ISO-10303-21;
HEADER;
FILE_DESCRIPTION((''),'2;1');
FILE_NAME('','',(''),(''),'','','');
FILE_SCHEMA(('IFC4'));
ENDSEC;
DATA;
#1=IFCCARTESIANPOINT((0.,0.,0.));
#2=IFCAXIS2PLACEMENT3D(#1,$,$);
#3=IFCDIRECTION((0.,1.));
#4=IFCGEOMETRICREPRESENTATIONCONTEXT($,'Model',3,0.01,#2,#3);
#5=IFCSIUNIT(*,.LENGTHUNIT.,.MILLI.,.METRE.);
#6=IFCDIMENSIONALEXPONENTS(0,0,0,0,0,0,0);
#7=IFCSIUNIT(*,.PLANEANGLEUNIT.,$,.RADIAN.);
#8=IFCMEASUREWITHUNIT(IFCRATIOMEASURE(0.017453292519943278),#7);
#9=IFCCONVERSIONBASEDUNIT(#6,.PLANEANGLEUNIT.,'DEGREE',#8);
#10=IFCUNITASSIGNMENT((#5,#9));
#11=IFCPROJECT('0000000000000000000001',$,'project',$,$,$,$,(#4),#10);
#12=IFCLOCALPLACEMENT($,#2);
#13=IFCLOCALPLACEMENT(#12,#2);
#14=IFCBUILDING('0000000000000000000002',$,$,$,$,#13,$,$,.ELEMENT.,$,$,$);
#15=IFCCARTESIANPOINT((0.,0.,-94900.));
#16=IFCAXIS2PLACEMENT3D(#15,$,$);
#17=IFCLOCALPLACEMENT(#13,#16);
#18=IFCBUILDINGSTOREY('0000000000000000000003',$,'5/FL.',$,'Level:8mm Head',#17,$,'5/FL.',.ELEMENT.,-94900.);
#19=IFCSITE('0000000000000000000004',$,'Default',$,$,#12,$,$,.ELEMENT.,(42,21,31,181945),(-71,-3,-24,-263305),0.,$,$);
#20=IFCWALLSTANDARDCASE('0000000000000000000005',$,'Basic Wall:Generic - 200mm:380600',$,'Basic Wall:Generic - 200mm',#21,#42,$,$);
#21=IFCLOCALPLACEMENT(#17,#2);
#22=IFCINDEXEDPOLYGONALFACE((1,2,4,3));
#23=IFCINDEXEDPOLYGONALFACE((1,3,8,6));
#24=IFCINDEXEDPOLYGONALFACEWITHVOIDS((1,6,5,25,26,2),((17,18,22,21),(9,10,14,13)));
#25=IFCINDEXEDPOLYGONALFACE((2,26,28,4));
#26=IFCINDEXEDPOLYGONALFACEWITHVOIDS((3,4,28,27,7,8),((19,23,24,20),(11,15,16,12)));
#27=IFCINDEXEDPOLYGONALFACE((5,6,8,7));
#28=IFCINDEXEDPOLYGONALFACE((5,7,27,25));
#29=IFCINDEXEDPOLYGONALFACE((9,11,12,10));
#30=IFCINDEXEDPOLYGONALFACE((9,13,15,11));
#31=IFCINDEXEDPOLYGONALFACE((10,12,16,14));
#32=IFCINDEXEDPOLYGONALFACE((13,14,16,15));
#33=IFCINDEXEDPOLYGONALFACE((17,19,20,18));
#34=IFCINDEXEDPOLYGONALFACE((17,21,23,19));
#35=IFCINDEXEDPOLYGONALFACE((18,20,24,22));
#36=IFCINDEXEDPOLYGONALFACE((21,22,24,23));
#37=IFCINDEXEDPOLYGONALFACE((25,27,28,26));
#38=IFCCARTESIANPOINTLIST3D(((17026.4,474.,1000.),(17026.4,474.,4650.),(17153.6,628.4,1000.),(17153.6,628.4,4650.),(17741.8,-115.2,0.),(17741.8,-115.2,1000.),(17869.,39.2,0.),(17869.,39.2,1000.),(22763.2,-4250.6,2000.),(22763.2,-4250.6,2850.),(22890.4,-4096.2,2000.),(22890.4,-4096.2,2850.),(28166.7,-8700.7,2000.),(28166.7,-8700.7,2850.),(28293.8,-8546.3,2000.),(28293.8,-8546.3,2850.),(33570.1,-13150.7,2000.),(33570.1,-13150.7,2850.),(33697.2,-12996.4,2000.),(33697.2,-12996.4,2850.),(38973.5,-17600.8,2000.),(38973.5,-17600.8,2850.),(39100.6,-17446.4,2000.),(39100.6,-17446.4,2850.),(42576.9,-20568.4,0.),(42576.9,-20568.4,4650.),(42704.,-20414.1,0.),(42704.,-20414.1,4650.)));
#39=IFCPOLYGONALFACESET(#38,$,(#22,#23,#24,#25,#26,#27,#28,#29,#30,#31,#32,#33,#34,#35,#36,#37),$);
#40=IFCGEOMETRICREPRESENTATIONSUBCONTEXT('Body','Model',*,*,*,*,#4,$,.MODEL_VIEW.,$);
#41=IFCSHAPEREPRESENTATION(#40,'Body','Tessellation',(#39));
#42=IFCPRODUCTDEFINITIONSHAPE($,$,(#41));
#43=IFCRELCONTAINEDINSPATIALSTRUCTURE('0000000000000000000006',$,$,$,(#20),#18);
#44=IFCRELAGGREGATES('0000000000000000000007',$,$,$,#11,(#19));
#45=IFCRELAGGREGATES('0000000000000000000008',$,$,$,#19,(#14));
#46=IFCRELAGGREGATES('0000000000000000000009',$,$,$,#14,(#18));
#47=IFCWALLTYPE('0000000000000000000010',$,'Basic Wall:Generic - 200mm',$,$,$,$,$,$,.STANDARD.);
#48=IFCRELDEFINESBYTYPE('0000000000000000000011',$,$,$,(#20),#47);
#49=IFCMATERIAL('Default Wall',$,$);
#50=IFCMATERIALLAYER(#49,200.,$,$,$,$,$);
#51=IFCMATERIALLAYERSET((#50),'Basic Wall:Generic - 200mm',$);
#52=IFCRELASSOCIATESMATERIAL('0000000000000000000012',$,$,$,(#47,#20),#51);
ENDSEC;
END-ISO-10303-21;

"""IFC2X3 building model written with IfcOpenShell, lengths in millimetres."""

from ifc_helpers import new_model, entity, si_unit, converted_unit, direction, frame, frame_2d, origin, place, context, subcontext, project, spatial, rectangle, extrude, material, layer, layer_set, layer_usage, type_object, element, save


model = new_model("IFC2X3")

# Units and contexts
model_context = context("Model", 3, precision=0.01, world=origin(), true_north=direction((0.0, 1.0)))
body_context = subcontext(model_context, "Body", "Model", "MODEL_VIEW")
ifc_project = project(units=[si_unit("LENGTHUNIT", "METRE", prefix="MILLI"), converted_unit("PLANEANGLEUNIT", "DEGREE", entity("IfcRatioMeasure", 0.017453292519943278), si_unit("PLANEANGLEUNIT", "RADIAN"), dimensions=[0, 0, 0, 0, 0, 0, 0])], contexts=[model_context])

# Site, building, storey
site_placement = place(None, origin())
site = spatial("IfcSite", under=ifc_project, at=site_placement, Name="Default", CompositionType="ELEMENT", RefLatitude=(42, 21, 31, 181945), RefLongitude=(-71, -3, -24, -263305), RefElevation=0.0)
building_placement = place(site_placement, origin())
building = spatial("IfcBuilding", under=site, at=building_placement, CompositionType="ELEMENT")
storey_placement = place(building_placement, frame((0.0, 0.0, -94900.0)))
storey = spatial("IfcBuildingStorey", under=building, at=storey_placement, Name="5/FL.", ObjectType="Level:8mm Head", LongName="5/FL.", CompositionType="ELEMENT", Elevation=-94900.0)

# Wall, openings
ifc_material_1 = material(Name="Default Wall")
ifc_layer = layer(ifc_material_1, 200.0)
ifc_layer_set = layer_set([ifc_layer], Name="Basic Wall:Generic - 200mm")
ifc_layer_usage = layer_usage(ifc_layer_set, "AXIS2", "NEGATIVE", 100.0)
wall_type = type_object("IfcWallType", Name="Basic Wall:Generic - 200mm", PredefinedType="STANDARD", material=ifc_layer_set)
wall_1_placement = place(storey_placement, frame((42640.5, -20491.3, 0.0), z_axis=(0.0, 0.0, 1.0), x_axis=(-0.771917, 0.635723, 0.0)))
wall_1 = element("IfcWallStandardCase", 1, at=wall_1_placement, inside=storey, type_object=wall_type, material=ifc_layer_usage, Name="Basic Wall:Generic - 200mm:380600", ObjectType="Basic Wall:Generic - 200mm", context=body_context, shape_type="SweptSolid", body=[
    extrude(rectangle(XDim=33100.0, YDim=200.0, at=frame_2d((16550.0, 0.0), x_axis=(-1.0, 0.0))), origin(), (0.0, 0.0, 1.0), 4650.0),
])
opening_1_placement = place(wall_1_placement, origin())
element("IfcOpeningElement", 2, at=opening_1_placement, cuts=wall_1, ObjectType="Opening", context=body_context, shape_type="SweptSolid", body=[
    extrude(rectangle(XDim=850.0, YDim=7000.0, at=frame_2d((0.0, 0.0), x_axis=(1.0, 0.0))), frame((8168.1, -100.0, 2425.0), z_axis=(0.0, 1.0, 0.0), x_axis=(0.0, 0.0, -1.0)), (0.0, 0.0, 1.0), 200.0),
])
opening_2_placement = place(wall_1_placement, origin())
element("IfcOpeningElement", 3, at=opening_2_placement, cuts=wall_1, ObjectType="Opening", context=body_context, shape_type="SweptSolid", body=[
    extrude(rectangle(XDim=850.0, YDim=7000.0, at=frame_2d((0.0, 0.0), x_axis=(1.0, 0.0))), frame((22168.1, -100.0, 2425.0), z_axis=(0.0, 1.0, 0.0), x_axis=(0.0, 0.0, -1.0)), (0.0, 0.0, 1.0), 200.0),
])
opening_3_placement = place(wall_1_placement, frame((45941.7, 11290.0, 0.0), z_axis=(0.0, 0.0, 1.0), x_axis=(-0.771917, -0.635723, 0.0)))
element("IfcOpeningElement", 4, at=opening_3_placement, cuts=wall_1, ObjectType="Opening", context=body_context, shape_type="SweptSolid", body=[
    extrude(rectangle(XDim=1000.0, YDim=1010.1, at=frame_2d((0.0, 0.0), x_axis=(1.0, 0.0))), frame((17487.2, 370.1, 500.0), z_axis=(-0.635723, -0.771917, 0.0), x_axis=(0.0, 0.0, -1.0)), (0.0, 0.0, 1.0), 1012.7),
])

save(model, "model.ifc")
